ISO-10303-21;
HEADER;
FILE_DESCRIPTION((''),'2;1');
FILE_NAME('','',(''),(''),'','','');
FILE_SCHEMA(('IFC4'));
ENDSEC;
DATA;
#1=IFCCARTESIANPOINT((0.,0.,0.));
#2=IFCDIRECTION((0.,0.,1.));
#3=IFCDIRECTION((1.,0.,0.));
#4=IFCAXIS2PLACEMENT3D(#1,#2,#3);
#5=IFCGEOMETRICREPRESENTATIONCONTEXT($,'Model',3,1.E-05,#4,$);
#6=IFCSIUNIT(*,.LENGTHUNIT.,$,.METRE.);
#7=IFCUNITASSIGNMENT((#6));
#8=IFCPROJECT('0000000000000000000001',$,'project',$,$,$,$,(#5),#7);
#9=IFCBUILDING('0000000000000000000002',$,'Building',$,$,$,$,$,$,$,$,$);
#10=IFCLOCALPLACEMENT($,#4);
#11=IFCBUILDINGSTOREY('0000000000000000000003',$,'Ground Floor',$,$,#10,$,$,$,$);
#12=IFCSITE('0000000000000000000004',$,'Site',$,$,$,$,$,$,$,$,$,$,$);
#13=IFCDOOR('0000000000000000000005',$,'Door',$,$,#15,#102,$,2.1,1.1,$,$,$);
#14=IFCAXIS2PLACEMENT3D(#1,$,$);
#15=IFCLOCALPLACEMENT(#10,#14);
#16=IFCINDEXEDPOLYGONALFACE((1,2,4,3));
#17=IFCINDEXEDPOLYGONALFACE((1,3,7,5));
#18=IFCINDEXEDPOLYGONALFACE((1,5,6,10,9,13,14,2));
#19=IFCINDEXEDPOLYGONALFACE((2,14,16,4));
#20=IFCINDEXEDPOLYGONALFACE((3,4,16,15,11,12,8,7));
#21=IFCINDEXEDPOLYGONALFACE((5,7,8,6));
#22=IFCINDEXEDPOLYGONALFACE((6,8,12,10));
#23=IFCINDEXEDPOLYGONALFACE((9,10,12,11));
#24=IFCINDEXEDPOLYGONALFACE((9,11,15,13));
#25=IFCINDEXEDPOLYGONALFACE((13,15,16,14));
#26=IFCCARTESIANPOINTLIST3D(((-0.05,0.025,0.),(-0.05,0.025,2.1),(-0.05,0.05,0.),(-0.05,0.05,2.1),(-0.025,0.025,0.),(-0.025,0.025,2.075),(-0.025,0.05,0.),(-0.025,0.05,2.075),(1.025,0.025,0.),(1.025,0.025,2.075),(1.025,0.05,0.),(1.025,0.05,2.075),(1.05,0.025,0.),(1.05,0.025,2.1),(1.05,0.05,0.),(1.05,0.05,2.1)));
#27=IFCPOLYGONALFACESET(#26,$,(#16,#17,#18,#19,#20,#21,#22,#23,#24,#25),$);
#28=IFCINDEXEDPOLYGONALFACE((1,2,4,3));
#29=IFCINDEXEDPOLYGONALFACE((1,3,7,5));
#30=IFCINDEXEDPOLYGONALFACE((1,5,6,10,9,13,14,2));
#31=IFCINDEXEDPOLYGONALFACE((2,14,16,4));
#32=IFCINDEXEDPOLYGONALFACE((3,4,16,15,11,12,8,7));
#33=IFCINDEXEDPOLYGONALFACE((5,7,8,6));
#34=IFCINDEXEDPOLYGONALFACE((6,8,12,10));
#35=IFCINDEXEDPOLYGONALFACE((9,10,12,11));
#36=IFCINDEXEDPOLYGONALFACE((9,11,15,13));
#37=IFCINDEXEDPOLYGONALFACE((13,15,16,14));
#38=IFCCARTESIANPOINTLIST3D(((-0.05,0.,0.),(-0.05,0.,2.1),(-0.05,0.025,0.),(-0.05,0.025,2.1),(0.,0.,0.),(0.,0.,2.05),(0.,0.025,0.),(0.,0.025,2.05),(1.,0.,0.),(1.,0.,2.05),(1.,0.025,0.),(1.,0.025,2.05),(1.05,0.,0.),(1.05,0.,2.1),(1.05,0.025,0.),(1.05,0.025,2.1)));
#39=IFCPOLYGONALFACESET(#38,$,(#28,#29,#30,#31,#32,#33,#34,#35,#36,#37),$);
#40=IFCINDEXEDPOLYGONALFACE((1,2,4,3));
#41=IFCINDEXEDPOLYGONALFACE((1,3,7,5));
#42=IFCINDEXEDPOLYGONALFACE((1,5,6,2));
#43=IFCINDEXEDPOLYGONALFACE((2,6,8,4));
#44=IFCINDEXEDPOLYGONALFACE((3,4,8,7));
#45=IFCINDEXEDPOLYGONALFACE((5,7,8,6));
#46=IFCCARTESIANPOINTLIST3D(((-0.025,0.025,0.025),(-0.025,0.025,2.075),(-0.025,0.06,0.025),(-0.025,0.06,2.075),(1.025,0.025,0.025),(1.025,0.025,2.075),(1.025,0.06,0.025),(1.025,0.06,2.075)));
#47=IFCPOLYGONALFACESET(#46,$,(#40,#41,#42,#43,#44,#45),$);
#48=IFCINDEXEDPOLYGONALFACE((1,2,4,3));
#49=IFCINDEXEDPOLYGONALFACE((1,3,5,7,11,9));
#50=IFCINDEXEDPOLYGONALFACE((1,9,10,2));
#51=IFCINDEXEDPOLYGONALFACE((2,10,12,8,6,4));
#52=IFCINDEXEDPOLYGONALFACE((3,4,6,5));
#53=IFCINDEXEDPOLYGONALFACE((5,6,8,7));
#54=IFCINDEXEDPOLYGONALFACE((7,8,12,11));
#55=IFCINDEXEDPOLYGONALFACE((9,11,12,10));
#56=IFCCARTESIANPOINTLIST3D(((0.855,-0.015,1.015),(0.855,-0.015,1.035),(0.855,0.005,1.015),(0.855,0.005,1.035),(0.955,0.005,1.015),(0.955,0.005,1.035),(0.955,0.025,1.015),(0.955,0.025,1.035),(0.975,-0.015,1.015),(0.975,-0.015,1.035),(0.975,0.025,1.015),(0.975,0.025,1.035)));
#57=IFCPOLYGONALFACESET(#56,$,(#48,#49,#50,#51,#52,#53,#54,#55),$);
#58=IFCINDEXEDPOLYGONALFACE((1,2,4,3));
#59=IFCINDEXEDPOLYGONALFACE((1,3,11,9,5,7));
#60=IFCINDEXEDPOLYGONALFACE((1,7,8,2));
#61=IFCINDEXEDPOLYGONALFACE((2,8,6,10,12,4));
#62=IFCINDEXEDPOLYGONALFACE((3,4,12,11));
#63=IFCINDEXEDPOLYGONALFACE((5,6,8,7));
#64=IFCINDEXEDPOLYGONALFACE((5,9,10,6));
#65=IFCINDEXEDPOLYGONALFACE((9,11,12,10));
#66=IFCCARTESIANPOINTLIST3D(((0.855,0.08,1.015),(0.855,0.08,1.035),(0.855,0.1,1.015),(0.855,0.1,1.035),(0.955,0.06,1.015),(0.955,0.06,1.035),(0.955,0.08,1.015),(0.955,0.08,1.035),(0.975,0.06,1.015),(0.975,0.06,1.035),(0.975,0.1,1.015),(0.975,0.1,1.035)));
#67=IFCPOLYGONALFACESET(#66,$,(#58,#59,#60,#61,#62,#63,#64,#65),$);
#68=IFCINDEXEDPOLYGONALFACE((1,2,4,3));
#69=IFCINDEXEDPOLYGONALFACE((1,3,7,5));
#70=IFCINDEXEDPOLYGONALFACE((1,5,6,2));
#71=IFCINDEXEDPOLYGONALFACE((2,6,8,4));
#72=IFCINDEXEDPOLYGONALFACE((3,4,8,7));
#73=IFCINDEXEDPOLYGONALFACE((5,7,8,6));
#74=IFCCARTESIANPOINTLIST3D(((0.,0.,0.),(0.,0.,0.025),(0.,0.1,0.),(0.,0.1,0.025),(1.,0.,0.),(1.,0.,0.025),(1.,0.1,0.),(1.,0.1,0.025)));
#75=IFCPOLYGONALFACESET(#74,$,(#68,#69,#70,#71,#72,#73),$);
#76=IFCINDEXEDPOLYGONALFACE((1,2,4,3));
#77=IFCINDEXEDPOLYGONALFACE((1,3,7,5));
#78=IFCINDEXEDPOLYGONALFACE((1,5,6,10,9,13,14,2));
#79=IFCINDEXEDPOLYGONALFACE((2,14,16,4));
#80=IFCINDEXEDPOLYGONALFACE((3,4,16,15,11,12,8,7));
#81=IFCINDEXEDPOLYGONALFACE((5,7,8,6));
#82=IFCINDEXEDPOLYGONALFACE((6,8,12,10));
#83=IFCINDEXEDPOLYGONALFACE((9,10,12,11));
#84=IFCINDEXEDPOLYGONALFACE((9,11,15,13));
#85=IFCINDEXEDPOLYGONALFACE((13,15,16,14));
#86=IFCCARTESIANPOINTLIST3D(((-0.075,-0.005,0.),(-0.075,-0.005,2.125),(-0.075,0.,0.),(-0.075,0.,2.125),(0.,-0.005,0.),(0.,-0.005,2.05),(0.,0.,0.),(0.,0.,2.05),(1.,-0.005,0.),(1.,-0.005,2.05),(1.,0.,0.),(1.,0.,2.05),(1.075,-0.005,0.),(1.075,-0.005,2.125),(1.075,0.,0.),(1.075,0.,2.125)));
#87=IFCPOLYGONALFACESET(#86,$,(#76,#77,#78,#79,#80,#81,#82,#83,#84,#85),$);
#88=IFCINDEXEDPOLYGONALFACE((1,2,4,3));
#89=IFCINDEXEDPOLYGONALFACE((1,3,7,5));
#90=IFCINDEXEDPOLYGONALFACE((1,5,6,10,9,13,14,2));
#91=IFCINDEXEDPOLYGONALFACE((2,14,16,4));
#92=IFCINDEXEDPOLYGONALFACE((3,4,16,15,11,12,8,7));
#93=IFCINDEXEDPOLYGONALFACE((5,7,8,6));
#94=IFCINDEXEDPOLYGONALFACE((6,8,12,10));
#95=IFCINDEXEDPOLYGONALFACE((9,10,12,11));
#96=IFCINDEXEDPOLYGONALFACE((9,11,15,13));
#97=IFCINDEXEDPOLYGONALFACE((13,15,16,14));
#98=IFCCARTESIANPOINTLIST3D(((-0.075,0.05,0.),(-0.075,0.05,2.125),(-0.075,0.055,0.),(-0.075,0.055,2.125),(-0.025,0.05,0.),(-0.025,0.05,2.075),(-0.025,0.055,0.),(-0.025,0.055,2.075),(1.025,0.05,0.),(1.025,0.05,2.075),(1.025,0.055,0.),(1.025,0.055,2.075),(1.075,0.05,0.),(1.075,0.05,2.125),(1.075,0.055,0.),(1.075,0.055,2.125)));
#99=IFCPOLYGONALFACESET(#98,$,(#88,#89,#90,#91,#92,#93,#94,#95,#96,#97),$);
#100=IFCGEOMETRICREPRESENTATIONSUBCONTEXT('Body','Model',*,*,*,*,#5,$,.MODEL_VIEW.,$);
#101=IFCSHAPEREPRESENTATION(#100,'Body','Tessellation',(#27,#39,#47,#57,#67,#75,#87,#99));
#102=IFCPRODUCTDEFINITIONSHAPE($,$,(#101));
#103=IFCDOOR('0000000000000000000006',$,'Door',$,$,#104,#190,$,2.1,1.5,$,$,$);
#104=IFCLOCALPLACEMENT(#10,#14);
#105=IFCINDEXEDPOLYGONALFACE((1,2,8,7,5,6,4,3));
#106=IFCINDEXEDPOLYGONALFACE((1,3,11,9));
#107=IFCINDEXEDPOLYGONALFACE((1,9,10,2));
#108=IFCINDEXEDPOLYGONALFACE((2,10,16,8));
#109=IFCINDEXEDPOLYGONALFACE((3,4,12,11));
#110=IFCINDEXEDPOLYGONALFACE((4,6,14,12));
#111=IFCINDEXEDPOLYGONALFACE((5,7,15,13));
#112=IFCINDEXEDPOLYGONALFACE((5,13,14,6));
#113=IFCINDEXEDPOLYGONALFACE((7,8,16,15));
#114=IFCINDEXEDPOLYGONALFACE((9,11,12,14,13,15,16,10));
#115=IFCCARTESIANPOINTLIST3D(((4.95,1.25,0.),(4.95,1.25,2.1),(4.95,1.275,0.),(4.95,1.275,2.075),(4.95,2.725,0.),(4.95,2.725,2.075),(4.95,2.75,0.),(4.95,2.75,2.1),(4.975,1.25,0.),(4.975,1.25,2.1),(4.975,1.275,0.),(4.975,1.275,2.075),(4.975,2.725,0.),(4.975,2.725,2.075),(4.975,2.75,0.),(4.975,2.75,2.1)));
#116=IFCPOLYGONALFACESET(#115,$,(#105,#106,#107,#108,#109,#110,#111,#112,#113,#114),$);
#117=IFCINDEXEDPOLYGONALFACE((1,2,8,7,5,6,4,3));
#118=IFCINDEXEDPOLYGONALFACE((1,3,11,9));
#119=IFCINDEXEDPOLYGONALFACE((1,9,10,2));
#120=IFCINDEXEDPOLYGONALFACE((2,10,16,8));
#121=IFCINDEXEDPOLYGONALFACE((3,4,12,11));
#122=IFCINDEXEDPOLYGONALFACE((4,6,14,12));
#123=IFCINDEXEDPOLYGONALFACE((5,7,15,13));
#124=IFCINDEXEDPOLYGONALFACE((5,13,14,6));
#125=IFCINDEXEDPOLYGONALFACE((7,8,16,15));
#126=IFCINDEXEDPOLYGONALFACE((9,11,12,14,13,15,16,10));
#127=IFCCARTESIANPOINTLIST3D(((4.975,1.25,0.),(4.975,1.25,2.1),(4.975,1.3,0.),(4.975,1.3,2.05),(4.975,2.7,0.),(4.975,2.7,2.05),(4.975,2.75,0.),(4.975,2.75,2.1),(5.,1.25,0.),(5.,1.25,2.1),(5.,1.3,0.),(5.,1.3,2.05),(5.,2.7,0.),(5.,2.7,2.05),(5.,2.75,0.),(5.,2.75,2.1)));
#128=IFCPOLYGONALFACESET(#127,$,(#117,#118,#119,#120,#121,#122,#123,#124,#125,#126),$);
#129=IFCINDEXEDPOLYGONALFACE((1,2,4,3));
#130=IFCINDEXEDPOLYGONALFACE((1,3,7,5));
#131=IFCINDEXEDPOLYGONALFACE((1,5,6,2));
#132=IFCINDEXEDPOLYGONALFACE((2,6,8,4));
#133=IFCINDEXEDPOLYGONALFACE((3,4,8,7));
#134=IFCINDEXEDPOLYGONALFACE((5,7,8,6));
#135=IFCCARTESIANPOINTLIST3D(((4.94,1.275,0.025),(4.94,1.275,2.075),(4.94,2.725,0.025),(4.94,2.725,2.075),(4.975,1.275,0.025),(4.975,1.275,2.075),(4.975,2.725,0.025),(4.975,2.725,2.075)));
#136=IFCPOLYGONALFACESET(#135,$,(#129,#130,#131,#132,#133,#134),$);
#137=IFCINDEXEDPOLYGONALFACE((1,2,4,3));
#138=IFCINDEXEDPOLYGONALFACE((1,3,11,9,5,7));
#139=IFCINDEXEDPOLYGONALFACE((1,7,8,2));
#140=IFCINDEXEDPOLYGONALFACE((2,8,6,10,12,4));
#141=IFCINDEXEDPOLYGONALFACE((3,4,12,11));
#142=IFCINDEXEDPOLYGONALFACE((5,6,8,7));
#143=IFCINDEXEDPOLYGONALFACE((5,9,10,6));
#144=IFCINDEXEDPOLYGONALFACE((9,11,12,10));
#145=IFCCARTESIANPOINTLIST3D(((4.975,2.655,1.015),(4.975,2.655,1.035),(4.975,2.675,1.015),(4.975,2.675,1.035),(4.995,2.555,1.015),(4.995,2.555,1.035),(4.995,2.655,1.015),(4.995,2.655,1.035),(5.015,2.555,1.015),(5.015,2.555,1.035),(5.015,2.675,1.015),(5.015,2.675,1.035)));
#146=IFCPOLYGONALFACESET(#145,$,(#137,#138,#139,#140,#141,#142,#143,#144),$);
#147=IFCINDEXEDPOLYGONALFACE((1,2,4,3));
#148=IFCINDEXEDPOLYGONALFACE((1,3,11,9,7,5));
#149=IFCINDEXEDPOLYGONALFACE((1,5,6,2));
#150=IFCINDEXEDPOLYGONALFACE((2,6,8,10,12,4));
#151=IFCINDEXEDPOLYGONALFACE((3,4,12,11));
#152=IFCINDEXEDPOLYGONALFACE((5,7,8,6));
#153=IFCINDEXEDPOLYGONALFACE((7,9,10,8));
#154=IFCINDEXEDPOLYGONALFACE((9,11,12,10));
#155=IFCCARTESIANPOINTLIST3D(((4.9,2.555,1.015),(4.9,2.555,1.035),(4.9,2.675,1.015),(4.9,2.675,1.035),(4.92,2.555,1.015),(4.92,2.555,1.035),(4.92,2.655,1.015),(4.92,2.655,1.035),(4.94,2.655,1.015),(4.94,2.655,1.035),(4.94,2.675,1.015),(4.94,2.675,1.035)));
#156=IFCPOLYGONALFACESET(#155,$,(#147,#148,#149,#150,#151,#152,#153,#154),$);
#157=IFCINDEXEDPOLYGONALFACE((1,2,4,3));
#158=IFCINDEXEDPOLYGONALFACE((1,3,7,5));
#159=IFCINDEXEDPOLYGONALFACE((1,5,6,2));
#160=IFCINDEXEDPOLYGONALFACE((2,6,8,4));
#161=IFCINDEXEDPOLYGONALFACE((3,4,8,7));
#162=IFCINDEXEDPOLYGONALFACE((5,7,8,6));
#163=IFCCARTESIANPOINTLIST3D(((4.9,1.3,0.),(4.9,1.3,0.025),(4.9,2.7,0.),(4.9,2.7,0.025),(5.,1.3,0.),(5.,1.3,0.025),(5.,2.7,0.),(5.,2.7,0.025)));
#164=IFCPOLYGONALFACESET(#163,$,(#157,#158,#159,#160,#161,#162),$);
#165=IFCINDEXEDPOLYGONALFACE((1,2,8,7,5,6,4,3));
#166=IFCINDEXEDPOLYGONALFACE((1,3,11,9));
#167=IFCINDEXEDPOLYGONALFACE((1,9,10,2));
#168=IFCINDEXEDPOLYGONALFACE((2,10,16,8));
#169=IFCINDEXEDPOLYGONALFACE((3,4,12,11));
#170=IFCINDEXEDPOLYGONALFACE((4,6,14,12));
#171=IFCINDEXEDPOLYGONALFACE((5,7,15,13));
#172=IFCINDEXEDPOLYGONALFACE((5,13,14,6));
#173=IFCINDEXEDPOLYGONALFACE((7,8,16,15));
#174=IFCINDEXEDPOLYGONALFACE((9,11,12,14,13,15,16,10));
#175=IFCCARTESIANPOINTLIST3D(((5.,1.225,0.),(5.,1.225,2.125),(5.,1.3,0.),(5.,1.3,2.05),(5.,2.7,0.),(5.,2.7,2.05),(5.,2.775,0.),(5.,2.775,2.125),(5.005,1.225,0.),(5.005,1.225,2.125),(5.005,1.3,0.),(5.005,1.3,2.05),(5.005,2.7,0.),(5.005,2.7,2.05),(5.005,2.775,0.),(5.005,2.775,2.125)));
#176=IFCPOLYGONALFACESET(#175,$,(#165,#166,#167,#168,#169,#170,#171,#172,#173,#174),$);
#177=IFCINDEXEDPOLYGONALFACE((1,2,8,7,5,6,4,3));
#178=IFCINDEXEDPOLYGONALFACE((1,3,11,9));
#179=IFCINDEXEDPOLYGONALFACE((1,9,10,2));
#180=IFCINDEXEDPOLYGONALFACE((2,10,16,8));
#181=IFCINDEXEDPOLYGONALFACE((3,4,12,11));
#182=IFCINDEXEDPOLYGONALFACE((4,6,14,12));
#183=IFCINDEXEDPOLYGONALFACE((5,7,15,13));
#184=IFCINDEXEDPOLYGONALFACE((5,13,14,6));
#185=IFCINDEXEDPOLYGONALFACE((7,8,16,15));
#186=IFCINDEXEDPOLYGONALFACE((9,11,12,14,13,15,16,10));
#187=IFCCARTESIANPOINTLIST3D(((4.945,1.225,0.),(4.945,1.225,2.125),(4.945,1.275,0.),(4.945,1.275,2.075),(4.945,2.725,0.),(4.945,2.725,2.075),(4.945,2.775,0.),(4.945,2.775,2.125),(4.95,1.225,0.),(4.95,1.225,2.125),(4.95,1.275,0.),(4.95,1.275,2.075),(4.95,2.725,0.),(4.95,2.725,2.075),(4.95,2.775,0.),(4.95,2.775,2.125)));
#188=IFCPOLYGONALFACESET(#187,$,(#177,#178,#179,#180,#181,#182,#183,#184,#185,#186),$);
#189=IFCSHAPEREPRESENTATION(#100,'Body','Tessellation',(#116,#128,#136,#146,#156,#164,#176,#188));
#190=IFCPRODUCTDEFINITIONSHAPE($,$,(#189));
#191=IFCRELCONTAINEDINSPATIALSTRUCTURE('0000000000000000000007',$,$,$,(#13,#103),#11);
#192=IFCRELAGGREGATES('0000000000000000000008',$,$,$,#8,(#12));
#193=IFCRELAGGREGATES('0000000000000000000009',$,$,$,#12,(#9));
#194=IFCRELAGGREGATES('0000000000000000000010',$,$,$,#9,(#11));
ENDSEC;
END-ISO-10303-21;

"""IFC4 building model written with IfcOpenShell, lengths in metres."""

from ifc_helpers import new_model, si_unit, frame, origin_with_axes, place, context, subcontext, project, spatial, line, indexed_curve, outline, extrude, element, save


model = new_model("IFC4")

# Units and contexts
model_context = context("Model", 3, precision=1e-05, world=origin_with_axes())
body_context = subcontext(model_context, "Body", "Model", "MODEL_VIEW")
ifc_project = project(units=[si_unit("LENGTHUNIT", "METRE")], contexts=[model_context])

# Site, building, storey
site = spatial("IfcSite", under=ifc_project, Name="Site")
building = spatial("IfcBuilding", under=site, Name="Building")
storey_placement = place(None, origin_with_axes())
storey = spatial("IfcBuildingStorey", under=building, at=storey_placement, Name="Ground Floor")

# Doors
door_1_placement = place(storey_placement, frame((-0.05, 0.0, 0.0), z_axis=(0.0, 0.0, 1.0), x_axis=(1.0, 0.0, 0.0)))
element("IfcDoor", 1, at=door_1_placement, inside=storey, Name="Door", OverallHeight=2.1, OverallWidth=1.1, context=body_context, shape_type="SweptSolid", body=[
    extrude(outline(indexed_curve([(0.0, 0.0), (0.0, 2.1), (1.1, 2.1), (1.1, 0.0), (1.075, 0.0), (1.075, 2.075), (0.025, 2.075), (0.025, 0.0)], segments=[line(1, 2, 3, 4, 5, 6, 7, 8, 1)])), frame((0.0, 0.025, 0.0), z_axis=(0.0, -1.0, 0.0), x_axis=(1.0, 0.0, 0.0)), (0.0, 0.0, -1.0), 0.025),
    extrude(outline(indexed_curve([(0.0, 0.0), (0.0, 2.1), (1.1, 2.1), (1.1, 0.0), (1.05, 0.0), (1.05, 2.05), (0.05, 2.05), (0.05, 0.0)], segments=[line(1, 2, 3, 4, 5, 6, 7, 8, 1)])), frame((0.0, 0.0, 0.0), z_axis=(0.0, -1.0, 0.0), x_axis=(1.0, 0.0, 0.0)), (0.0, 0.0, -1.0), 0.025),
    extrude(outline(indexed_curve([(0.0, 0.0), (1.05, 0.0), (1.05, 0.035), (0.0, 0.035)], segments=[line(1, 2, 3, 4, 1)])), frame((0.025, 0.025, 0.025), z_axis=(0.0, 0.0, 1.0), x_axis=(1.0, 0.0, 0.0)), (0.0, 0.0, 1.0), 2.05),
    extrude(outline(indexed_curve([(0.0, 0.0), (0.0, -0.04), (-0.12, -0.04), (-0.12, -0.02), (-0.02, -0.02), (-0.02, 0.0)], segments=[line(1, 2, 3, 4, 5, 6, 1)])), frame((1.025, 0.025, 1.015), z_axis=(0.0, 0.0, 1.0), x_axis=(1.0, 0.0, 0.0)), (0.0, 0.0, 1.0), 0.02),
    extrude(outline(indexed_curve([(0.0, 0.0), (0.0, 0.04), (-0.12, 0.04), (-0.12, 0.02), (-0.02, 0.02), (-0.02, 0.0)], segments=[line(1, 2, 3, 4, 5, 6, 1)])), frame((1.025, 0.06, 1.015), z_axis=(0.0, 0.0, 1.0), x_axis=(1.0, 0.0, 0.0)), (0.0, 0.0, 1.0), 0.02),
    extrude(outline(indexed_curve([(0.0, 0.0), (1.0, 0.0), (1.0, 0.1), (0.0, 0.1)], segments=[line(1, 2, 3, 4, 1)])), frame((0.05, 0.0, 0.0), z_axis=(0.0, 0.0, 1.0), x_axis=(1.0, 0.0, 0.0)), (0.0, 0.0, 1.0), 0.025),
    extrude(outline(indexed_curve([(0.0, 0.0), (0.0, 2.125), (1.15, 2.125), (1.15, 0.0), (1.075, 0.0), (1.075, 2.05), (0.075, 2.05), (0.075, 0.0)], segments=[line(1, 2, 3, 4, 5, 6, 7, 8, 1)])), frame((-0.025, -0.005, 0.0), z_axis=(0.0, -1.0, 0.0), x_axis=(1.0, 0.0, 0.0)), (0.0, 0.0, -1.0), 0.005),
    extrude(outline(indexed_curve([(0.0, 0.0), (0.0, 2.125), (1.15, 2.125), (1.15, 0.0), (1.1, 0.0), (1.1, 2.075), (0.05, 2.075), (0.05, 0.0)], segments=[line(1, 2, 3, 4, 5, 6, 7, 8, 1)])), frame((-0.025, 0.05, 0.0), z_axis=(0.0, -1.0, 0.0), x_axis=(1.0, 0.0, 0.0)), (0.0, 0.0, -1.0), 0.005),
])
door_2_placement = place(storey_placement, frame((5.0, 1.25, 0.0), z_axis=(0.0, 0.0, 1.0), x_axis=(0.0, 1.0, 0.0)))
element("IfcDoor", 2, at=door_2_placement, inside=storey, Name="Door", OverallHeight=2.1, OverallWidth=1.5, context=body_context, shape_type="SweptSolid", body=[
    extrude(outline(indexed_curve([(0.0, 0.0), (0.0, 2.1), (1.5, 2.1), (1.5, 0.0), (1.475, 0.0), (1.475, 2.075), (0.025, 2.075), (0.025, 0.0)], segments=[line(1, 2, 3, 4, 5, 6, 7, 8, 1)])), frame((0.0, 0.025, 0.0), z_axis=(0.0, -1.0, 0.0), x_axis=(1.0, 0.0, 0.0)), (0.0, 0.0, -1.0), 0.025),
    extrude(outline(indexed_curve([(0.0, 0.0), (0.0, 2.1), (1.5, 2.1), (1.5, 0.0), (1.45, 0.0), (1.45, 2.05), (0.05, 2.05), (0.05, 0.0)], segments=[line(1, 2, 3, 4, 5, 6, 7, 8, 1)])), frame((0.0, 0.0, 0.0), z_axis=(0.0, -1.0, 0.0), x_axis=(1.0, 0.0, 0.0)), (0.0, 0.0, -1.0), 0.025),
    extrude(outline(indexed_curve([(0.0, 0.0), (1.45, 0.0), (1.45, 0.035), (0.0, 0.035)], segments=[line(1, 2, 3, 4, 1)])), frame((0.025, 0.025, 0.025), z_axis=(0.0, 0.0, 1.0), x_axis=(1.0, 0.0, 0.0)), (0.0, 0.0, 1.0), 2.05),
    extrude(outline(indexed_curve([(0.0, 0.0), (0.0, -0.04), (-0.12, -0.04), (-0.12, -0.02), (-0.02, -0.02), (-0.02, 0.0)], segments=[line(1, 2, 3, 4, 5, 6, 1)])), frame((1.425, 0.025, 1.015), z_axis=(0.0, 0.0, 1.0), x_axis=(1.0, 0.0, 0.0)), (0.0, 0.0, 1.0), 0.02),
    extrude(outline(indexed_curve([(0.0, 0.0), (0.0, 0.04), (-0.12, 0.04), (-0.12, 0.02), (-0.02, 0.02), (-0.02, 0.0)], segments=[line(1, 2, 3, 4, 5, 6, 1)])), frame((1.425, 0.06, 1.015), z_axis=(0.0, 0.0, 1.0), x_axis=(1.0, 0.0, 0.0)), (0.0, 0.0, 1.0), 0.02),
    extrude(outline(indexed_curve([(0.0, 0.0), (1.4, 0.0), (1.4, 0.1), (0.0, 0.1)], segments=[line(1, 2, 3, 4, 1)])), frame((0.05, 0.0, 0.0), z_axis=(0.0, 0.0, 1.0), x_axis=(1.0, 0.0, 0.0)), (0.0, 0.0, 1.0), 0.025),
    extrude(outline(indexed_curve([(0.0, 0.0), (0.0, 2.125), (1.55, 2.125), (1.55, 0.0), (1.475, 0.0), (1.475, 2.05), (0.075, 2.05), (0.075, 0.0)], segments=[line(1, 2, 3, 4, 5, 6, 7, 8, 1)])), frame((-0.025, -0.005, 0.0), z_axis=(0.0, -1.0, 0.0), x_axis=(1.0, 0.0, 0.0)), (0.0, 0.0, -1.0), 0.005),
    extrude(outline(indexed_curve([(0.0, 0.0), (0.0, 2.125), (1.55, 2.125), (1.55, 0.0), (1.5, 0.0), (1.5, 2.075), (0.05, 2.075), (0.05, 0.0)], segments=[line(1, 2, 3, 4, 5, 6, 7, 8, 1)])), frame((-0.025, 0.05, 0.0), z_axis=(0.0, -1.0, 0.0), x_axis=(1.0, 0.0, 0.0)), (0.0, 0.0, -1.0), 0.005),
])

save(model, "model.ifc")
